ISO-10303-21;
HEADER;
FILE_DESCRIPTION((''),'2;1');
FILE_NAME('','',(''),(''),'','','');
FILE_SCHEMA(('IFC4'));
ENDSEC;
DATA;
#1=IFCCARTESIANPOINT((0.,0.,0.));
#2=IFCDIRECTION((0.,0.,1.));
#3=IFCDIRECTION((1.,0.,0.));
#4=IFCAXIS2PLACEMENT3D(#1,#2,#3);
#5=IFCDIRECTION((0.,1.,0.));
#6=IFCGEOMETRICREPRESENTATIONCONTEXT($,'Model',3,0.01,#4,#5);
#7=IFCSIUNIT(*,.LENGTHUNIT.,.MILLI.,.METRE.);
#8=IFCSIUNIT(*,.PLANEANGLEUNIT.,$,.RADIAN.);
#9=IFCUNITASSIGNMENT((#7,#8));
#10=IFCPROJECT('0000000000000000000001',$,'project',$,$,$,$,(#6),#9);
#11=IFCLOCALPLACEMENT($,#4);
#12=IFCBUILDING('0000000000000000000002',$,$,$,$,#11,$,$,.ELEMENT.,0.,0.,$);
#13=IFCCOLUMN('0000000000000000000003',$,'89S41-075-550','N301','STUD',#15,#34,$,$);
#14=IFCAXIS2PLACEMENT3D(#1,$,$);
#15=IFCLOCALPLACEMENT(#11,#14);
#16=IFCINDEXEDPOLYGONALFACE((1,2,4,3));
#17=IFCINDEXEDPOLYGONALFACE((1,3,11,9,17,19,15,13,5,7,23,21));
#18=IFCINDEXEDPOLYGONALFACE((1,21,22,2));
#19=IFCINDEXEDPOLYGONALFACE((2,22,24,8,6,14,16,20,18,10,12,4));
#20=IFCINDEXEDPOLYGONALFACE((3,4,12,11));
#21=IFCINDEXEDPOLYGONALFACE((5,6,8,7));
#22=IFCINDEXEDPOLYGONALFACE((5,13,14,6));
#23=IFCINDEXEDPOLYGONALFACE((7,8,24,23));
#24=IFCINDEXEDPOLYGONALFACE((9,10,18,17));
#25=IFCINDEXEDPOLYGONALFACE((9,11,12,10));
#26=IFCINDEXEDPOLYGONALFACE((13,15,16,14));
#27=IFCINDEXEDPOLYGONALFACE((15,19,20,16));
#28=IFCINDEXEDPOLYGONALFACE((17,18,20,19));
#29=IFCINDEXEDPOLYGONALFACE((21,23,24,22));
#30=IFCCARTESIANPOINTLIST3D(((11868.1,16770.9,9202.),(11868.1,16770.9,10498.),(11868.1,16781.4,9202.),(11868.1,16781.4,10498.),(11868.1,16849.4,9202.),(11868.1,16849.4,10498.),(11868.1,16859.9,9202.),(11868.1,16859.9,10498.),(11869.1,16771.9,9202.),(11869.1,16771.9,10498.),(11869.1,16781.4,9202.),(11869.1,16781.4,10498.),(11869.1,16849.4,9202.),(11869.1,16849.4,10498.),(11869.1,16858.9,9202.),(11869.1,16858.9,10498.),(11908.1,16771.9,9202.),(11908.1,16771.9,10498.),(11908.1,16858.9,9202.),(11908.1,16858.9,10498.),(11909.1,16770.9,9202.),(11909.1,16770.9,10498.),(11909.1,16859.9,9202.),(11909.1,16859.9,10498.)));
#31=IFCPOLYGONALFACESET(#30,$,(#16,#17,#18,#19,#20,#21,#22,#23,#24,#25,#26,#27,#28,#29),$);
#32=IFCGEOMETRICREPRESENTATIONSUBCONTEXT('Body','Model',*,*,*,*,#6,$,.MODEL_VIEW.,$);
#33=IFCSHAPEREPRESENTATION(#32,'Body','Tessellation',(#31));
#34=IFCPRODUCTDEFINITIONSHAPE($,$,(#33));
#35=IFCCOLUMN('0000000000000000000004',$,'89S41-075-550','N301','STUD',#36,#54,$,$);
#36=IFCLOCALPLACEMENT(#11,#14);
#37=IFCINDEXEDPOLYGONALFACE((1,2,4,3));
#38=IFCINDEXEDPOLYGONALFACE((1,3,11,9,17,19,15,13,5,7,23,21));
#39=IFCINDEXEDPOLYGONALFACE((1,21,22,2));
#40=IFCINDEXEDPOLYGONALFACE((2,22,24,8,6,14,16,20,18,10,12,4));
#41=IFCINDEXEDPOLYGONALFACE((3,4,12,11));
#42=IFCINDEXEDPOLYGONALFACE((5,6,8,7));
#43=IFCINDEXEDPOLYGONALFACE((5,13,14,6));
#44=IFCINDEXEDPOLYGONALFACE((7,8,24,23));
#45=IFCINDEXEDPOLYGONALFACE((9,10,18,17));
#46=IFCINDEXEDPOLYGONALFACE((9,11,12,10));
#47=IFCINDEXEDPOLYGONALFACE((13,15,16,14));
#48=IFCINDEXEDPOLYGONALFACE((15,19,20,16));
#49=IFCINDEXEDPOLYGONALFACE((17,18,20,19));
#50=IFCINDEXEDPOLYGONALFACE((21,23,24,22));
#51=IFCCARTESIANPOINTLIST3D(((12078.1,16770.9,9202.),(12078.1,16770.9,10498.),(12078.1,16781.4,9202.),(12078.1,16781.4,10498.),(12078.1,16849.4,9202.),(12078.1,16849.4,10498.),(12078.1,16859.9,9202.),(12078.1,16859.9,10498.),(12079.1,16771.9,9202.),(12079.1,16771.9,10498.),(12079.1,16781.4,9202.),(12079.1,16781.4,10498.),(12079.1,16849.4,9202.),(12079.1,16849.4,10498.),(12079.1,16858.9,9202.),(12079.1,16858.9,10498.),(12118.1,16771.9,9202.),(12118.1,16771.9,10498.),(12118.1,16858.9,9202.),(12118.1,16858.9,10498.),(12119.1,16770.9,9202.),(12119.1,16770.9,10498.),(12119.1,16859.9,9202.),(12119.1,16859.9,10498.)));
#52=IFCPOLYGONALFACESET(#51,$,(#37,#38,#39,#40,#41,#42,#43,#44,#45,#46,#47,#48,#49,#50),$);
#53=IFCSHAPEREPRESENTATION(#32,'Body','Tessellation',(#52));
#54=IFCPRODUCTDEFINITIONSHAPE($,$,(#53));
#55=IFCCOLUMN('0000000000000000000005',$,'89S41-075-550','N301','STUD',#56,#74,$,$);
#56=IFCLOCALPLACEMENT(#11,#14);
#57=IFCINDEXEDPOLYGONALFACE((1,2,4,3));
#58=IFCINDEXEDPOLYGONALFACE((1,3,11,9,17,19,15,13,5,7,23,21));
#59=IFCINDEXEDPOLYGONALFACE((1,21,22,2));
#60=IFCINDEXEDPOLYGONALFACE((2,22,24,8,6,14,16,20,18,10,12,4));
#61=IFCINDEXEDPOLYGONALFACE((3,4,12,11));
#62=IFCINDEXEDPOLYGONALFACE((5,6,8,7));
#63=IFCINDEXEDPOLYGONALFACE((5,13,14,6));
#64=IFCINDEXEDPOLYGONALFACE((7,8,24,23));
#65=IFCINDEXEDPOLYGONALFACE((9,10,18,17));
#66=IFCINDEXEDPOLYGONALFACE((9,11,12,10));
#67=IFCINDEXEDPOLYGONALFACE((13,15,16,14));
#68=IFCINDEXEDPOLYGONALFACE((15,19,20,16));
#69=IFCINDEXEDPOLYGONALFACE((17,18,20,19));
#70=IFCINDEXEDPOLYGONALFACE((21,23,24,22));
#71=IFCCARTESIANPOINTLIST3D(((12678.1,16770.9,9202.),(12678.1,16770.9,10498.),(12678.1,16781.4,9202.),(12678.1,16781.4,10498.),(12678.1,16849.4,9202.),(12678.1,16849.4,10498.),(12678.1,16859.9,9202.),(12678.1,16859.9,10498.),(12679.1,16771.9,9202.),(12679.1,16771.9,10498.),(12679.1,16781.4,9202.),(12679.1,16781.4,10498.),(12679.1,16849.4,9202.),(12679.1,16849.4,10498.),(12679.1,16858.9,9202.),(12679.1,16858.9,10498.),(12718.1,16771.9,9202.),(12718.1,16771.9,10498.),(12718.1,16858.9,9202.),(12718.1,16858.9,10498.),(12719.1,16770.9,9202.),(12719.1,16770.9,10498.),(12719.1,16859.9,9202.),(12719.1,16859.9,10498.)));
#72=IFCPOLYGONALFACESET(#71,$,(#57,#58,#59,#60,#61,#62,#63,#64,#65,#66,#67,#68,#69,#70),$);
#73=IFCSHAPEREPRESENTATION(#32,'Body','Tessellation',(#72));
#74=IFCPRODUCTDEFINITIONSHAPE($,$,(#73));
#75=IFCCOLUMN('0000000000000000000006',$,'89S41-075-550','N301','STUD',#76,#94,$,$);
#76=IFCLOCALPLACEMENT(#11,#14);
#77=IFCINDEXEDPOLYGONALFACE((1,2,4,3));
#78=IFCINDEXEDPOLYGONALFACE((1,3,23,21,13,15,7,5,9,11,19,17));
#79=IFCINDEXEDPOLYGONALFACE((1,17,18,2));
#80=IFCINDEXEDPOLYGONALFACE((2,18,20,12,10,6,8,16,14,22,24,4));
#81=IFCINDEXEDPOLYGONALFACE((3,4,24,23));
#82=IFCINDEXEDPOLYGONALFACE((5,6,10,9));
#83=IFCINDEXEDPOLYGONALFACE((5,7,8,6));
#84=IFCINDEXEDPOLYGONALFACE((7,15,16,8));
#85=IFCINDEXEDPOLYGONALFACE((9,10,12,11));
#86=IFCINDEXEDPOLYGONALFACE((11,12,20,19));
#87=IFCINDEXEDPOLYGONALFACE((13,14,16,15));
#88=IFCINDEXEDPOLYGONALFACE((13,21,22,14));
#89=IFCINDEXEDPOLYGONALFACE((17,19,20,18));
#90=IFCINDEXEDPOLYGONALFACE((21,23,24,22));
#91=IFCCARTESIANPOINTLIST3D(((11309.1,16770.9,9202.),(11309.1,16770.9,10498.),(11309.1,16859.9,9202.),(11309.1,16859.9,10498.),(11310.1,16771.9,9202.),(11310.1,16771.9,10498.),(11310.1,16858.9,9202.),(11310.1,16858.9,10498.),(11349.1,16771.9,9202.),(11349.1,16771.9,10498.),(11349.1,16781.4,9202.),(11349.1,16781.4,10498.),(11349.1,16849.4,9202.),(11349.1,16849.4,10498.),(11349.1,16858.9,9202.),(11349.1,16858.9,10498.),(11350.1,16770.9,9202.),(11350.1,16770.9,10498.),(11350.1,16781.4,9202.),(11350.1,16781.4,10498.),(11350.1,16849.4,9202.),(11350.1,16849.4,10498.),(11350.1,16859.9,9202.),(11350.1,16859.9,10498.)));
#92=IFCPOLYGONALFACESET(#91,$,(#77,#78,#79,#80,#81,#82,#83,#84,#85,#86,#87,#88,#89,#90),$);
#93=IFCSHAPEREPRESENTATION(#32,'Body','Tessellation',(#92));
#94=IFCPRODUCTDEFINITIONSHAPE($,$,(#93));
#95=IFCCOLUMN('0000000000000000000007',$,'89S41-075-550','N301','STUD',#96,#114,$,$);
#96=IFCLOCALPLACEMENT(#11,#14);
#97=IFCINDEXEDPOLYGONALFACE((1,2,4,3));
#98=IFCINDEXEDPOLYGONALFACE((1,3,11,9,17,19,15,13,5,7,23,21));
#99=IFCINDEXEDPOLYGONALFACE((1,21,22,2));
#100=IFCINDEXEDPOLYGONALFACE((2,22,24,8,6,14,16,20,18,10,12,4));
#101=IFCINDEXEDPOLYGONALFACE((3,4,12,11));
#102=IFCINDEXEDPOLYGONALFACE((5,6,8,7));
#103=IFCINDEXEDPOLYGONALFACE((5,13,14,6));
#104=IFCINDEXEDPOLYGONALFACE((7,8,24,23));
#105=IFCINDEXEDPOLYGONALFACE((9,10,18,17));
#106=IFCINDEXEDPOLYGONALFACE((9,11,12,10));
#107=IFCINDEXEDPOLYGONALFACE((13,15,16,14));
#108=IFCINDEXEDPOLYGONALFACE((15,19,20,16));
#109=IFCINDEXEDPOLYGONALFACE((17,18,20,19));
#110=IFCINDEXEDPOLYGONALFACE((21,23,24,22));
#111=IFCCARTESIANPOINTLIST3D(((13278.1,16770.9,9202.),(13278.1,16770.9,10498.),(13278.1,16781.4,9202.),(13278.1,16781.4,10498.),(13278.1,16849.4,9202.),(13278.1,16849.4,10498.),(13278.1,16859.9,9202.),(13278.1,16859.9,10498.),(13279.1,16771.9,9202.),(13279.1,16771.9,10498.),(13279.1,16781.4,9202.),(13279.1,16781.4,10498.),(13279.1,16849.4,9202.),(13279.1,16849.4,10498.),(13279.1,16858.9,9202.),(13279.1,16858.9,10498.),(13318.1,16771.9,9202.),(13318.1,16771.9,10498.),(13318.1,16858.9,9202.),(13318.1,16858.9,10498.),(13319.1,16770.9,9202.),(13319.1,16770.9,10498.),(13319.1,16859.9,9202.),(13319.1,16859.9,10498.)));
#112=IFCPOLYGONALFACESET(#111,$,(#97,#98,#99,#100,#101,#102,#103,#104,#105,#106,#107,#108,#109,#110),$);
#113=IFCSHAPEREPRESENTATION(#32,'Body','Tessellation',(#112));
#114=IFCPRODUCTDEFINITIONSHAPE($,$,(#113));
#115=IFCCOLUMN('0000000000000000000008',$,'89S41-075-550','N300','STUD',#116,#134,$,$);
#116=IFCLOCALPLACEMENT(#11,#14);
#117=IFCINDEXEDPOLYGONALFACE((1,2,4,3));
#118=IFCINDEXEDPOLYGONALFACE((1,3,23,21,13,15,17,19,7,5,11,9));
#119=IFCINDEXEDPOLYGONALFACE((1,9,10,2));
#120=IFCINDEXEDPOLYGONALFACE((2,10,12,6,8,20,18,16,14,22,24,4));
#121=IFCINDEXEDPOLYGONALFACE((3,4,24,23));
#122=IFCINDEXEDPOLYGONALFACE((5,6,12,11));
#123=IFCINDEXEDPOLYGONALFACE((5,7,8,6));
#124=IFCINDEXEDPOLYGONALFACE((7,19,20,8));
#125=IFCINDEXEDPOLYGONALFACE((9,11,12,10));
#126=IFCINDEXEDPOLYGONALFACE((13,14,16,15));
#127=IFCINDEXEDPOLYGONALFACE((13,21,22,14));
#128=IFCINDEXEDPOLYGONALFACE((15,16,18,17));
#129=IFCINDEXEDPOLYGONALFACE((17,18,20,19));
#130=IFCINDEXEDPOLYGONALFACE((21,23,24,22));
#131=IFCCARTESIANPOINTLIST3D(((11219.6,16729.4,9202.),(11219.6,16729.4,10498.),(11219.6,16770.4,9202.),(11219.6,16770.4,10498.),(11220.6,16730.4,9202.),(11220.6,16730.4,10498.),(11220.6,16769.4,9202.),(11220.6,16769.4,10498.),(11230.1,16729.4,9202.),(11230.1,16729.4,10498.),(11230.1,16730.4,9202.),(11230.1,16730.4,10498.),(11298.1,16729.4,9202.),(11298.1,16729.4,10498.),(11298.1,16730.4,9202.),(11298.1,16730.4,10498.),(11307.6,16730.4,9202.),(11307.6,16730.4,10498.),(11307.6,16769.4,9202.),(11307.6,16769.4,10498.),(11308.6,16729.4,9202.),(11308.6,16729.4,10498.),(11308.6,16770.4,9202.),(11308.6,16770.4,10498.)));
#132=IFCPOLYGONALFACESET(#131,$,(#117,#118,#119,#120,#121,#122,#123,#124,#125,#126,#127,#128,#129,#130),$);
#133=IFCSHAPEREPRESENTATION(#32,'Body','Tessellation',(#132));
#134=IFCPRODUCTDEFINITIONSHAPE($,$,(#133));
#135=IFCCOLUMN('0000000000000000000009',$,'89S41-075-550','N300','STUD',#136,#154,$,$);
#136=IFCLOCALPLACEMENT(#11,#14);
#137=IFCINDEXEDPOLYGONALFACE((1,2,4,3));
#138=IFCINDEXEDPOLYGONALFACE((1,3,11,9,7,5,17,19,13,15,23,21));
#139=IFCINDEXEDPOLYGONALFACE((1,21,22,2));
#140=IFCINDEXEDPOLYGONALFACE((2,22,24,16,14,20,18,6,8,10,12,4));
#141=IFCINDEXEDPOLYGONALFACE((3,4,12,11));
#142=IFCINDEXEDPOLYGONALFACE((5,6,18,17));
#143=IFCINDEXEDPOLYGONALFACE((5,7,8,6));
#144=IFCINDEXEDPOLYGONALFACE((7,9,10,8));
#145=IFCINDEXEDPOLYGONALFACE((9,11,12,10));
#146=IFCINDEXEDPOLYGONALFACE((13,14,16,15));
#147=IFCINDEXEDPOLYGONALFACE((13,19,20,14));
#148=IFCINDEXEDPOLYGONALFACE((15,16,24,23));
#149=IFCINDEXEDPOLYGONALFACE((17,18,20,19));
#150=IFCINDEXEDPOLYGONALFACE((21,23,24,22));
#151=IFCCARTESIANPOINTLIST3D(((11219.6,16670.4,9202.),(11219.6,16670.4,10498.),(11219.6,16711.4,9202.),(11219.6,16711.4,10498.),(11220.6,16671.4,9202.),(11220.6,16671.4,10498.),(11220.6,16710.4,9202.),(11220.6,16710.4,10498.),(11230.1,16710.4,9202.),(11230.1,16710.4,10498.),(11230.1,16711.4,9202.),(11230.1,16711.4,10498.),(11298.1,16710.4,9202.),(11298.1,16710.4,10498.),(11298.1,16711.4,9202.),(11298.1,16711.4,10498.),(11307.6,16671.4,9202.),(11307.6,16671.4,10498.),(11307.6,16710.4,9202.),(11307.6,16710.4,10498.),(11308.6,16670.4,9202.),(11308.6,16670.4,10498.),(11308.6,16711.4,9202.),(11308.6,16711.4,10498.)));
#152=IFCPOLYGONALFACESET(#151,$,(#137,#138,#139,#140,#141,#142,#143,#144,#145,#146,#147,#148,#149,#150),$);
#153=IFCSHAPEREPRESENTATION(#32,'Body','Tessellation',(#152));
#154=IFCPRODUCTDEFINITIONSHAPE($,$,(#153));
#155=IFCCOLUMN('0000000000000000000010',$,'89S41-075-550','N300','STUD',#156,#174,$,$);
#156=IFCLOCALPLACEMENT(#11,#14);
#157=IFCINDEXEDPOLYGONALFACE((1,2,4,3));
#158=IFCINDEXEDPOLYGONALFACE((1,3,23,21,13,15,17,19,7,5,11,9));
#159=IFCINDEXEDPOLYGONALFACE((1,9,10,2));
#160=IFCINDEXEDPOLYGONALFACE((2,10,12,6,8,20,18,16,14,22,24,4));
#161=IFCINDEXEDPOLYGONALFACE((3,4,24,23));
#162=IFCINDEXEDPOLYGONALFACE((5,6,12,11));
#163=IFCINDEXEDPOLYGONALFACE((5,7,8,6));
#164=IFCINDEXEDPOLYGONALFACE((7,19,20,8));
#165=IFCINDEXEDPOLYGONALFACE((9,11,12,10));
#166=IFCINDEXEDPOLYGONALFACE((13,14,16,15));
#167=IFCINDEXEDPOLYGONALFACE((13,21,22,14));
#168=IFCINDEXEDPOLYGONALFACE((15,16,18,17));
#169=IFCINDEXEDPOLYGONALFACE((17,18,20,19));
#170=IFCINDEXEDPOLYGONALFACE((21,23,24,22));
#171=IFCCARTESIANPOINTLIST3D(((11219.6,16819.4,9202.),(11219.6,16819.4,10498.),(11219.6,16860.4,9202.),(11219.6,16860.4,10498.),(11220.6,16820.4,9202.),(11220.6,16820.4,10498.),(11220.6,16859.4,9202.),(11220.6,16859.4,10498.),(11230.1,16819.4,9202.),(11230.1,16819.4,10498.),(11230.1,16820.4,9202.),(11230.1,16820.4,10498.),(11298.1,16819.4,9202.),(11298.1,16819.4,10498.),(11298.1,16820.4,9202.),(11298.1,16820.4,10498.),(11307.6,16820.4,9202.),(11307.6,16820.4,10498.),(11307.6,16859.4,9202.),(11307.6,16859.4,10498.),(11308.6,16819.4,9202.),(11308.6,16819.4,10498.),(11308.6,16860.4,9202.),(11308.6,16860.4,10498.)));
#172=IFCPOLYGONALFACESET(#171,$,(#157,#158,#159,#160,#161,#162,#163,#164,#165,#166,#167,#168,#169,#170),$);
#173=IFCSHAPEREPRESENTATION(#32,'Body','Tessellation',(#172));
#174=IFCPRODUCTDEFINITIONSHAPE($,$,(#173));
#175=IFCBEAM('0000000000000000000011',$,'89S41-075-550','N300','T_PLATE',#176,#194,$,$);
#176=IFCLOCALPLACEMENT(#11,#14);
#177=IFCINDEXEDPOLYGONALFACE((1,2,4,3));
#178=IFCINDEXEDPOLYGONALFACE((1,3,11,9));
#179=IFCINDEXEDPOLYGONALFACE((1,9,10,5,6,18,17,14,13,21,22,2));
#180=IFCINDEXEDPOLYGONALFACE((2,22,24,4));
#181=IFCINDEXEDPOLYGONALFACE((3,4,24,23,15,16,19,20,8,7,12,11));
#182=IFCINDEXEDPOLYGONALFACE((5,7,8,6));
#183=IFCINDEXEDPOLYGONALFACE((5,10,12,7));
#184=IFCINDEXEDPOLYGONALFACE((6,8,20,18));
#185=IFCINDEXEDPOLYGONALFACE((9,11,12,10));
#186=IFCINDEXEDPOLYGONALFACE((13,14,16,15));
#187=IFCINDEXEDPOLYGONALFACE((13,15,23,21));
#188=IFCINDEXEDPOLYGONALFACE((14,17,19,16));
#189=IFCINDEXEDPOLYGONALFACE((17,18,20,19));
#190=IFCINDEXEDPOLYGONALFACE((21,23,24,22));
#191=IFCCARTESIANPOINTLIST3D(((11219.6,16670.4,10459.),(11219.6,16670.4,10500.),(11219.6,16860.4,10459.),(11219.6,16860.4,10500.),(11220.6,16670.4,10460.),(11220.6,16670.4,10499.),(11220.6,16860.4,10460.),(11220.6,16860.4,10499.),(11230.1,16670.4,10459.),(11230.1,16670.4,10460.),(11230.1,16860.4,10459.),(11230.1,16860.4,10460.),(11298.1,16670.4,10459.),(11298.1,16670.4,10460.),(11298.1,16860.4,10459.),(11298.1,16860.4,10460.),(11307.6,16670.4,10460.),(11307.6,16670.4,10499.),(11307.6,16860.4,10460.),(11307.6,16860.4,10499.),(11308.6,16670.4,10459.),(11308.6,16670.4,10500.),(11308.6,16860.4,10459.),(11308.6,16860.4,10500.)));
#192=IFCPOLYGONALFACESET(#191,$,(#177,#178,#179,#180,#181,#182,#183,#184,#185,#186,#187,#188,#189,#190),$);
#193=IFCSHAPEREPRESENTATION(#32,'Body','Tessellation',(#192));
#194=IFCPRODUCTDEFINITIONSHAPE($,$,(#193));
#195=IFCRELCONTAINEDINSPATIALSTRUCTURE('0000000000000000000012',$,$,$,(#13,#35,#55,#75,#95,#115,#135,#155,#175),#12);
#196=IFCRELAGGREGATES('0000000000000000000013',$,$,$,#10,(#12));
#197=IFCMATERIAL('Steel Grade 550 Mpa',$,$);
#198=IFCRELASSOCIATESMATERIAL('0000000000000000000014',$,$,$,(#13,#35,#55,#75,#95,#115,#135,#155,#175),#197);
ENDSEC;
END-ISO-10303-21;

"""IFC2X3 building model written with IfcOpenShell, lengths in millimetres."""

from ifc_helpers import new_model, si_unit, direction, frame, origin, origin_with_axes, origin_2d_with_axis, place, context, subcontext, project, spatial, c_section, extrude, source, transform, mapped, material, element, save


model = new_model("IFC2X3")

# Units and contexts
model_context = context("Model", 3, precision=0.01, world=origin_with_axes(), true_north=direction((0.0, 1.0, 0.0)))
body_context = subcontext(model_context, "Body", "Model", "MODEL_VIEW")
ifc_project = project(units=[si_unit("LENGTHUNIT", "METRE", prefix="MILLI"), si_unit("PLANEANGLEUNIT", "RADIAN")], contexts=[model_context])

# Building
building_placement = place(None, origin_with_axes())
building = spatial("IfcBuilding", under=ifc_project, at=building_placement, CompositionType="ELEMENT", ElevationOfRefHeight=0.0, ElevationOfTerrain=0.0)

# Columns
ifc_material_1 = material(Name="Steel Grade 550 Mpa")
shared_shape_1 = source(origin(), body_context, "Body", "SweptSolid", [
    extrude(c_section(Depth=89.0, Width=41.0, WallThickness=1.0, Girth=10.5, at=origin_2d_with_axis()), origin_with_axes(), (0.0, 0.0, 1.0), 1296.0),
])
column_1_placement = place(None, frame((11888.6, 16815.4, 9202.0), z_axis=(0.0, 0.0, 1.0), x_axis=(-1.0, 0.0, 0.0)))
element("IfcColumn", 1, at=column_1_placement, inside=building, material=ifc_material_1, Name="89S41-075-550", Description="N301", ObjectType="STUD", context=body_context, shape_type="MappedRepresentation", body=[
    mapped(shared_shape_1, transform((0.0, 0.0, 0.0), scale=1.0)),
])
shared_shape_2 = source(origin(), body_context, "Body", "SweptSolid", [
    extrude(c_section(Depth=89.0, Width=41.0, WallThickness=1.0, Girth=10.5, at=origin_2d_with_axis()), origin_with_axes(), (0.0, 0.0, 1.0), 1296.0),
])
column_2_placement = place(None, frame((12098.6, 16815.4, 9202.0), z_axis=(0.0, 0.0, 1.0), x_axis=(-1.0, 0.0, 0.0)))
element("IfcColumn", 2, at=column_2_placement, inside=building, material=ifc_material_1, Name="89S41-075-550", Description="N301", ObjectType="STUD", context=body_context, shape_type="MappedRepresentation", body=[
    mapped(shared_shape_2, transform((0.0, 0.0, 0.0), scale=1.0)),
])
shared_shape_3 = source(origin(), body_context, "Body", "SweptSolid", [
    extrude(c_section(Depth=89.0, Width=41.0, WallThickness=1.0, Girth=10.5, at=origin_2d_with_axis()), origin_with_axes(), (0.0, 0.0, 1.0), 1296.0),
])
column_3_placement = place(None, frame((12698.6, 16815.4, 9202.0), z_axis=(0.0, 0.0, 1.0), x_axis=(-1.0, 0.0, 0.0)))
element("IfcColumn", 3, at=column_3_placement, inside=building, material=ifc_material_1, Name="89S41-075-550", Description="N301", ObjectType="STUD", context=body_context, shape_type="MappedRepresentation", body=[
    mapped(shared_shape_3, transform((0.0, 0.0, 0.0), scale=1.0)),
])
shared_shape_4 = source(origin(), body_context, "Body", "SweptSolid", [
    extrude(c_section(Depth=89.0, Width=41.0, WallThickness=1.0, Girth=10.5, at=origin_2d_with_axis()), origin_with_axes(), (0.0, 0.0, 1.0), 1296.0),
])
column_4_placement = place(None, frame((11329.6, 16815.4, 9202.0), z_axis=(0.0, 0.0, 1.0), x_axis=(1.0, 0.0, 0.0)))
element("IfcColumn", 4, at=column_4_placement, inside=building, material=ifc_material_1, Name="89S41-075-550", Description="N301", ObjectType="STUD", context=body_context, shape_type="MappedRepresentation", body=[
    mapped(shared_shape_4, transform((0.0, 0.0, 0.0), scale=1.0)),
])
shared_shape_5 = source(origin(), body_context, "Body", "SweptSolid", [
    extrude(c_section(Depth=89.0, Width=41.0, WallThickness=1.0, Girth=10.5, at=origin_2d_with_axis()), origin_with_axes(), (0.0, 0.0, 1.0), 1296.0),
])
column_5_placement = place(None, frame((13298.6, 16815.4, 9202.0), z_axis=(0.0, 0.0, 1.0), x_axis=(-1.0, 0.0, 0.0)))
element("IfcColumn", 5, at=column_5_placement, inside=building, material=ifc_material_1, Name="89S41-075-550", Description="N301", ObjectType="STUD", context=body_context, shape_type="MappedRepresentation", body=[
    mapped(shared_shape_5, transform((0.0, 0.0, 0.0), scale=1.0)),
])
shared_shape_6 = source(origin(), body_context, "Body", "SweptSolid", [
    extrude(c_section(Depth=89.0, Width=41.0, WallThickness=1.0, Girth=10.5, at=origin_2d_with_axis()), origin_with_axes(), (0.0, 0.0, 1.0), 1296.0),
])
column_6_placement = place(None, frame((11264.1, 16749.9, 9202.0), z_axis=(0.0, 0.0, 1.0), x_axis=(0.0, -1.0, 0.0)))
element("IfcColumn", 6, at=column_6_placement, inside=building, material=ifc_material_1, Name="89S41-075-550", Description="N300", ObjectType="STUD", context=body_context, shape_type="MappedRepresentation", body=[
    mapped(shared_shape_6, transform((0.0, 0.0, 0.0), scale=1.0)),
])
shared_shape_7 = source(origin(), body_context, "Body", "SweptSolid", [
    extrude(c_section(Depth=89.0, Width=41.0, WallThickness=1.0, Girth=10.5, at=origin_2d_with_axis()), origin_with_axes(), (0.0, 0.0, 1.0), 1296.0),
])
column_7_placement = place(None, frame((11264.1, 16690.9, 9202.0), z_axis=(0.0, 0.0, 1.0), x_axis=(0.0, 1.0, 0.0)))
element("IfcColumn", 7, at=column_7_placement, inside=building, material=ifc_material_1, Name="89S41-075-550", Description="N300", ObjectType="STUD", context=body_context, shape_type="MappedRepresentation", body=[
    mapped(shared_shape_7, transform((0.0, 0.0, 0.0), scale=1.0)),
])
shared_shape_8 = source(origin(), body_context, "Body", "SweptSolid", [
    extrude(c_section(Depth=89.0, Width=41.0, WallThickness=1.0, Girth=10.5, at=origin_2d_with_axis()), origin_with_axes(), (0.0, 0.0, 1.0), 1296.0),
])
column_8_placement = place(None, frame((11264.1, 16839.9, 9202.0), z_axis=(0.0, 0.0, 1.0), x_axis=(0.0, -1.0, 0.0)))
element("IfcColumn", 8, at=column_8_placement, inside=building, material=ifc_material_1, Name="89S41-075-550", Description="N300", ObjectType="STUD", context=body_context, shape_type="MappedRepresentation", body=[
    mapped(shared_shape_8, transform((0.0, 0.0, 0.0), scale=1.0)),
])

# Beam
shared_shape_9 = source(origin(), body_context, "Body", "SweptSolid", [
    extrude(c_section(Depth=89.0, Width=41.0, WallThickness=1.0, Girth=10.5, at=origin_2d_with_axis()), origin_with_axes(), (0.0, 0.0, 1.0), 190.0),
])
beam_1_placement = place(None, frame((11264.1, 16860.4, 10479.5), z_axis=(0.0, -1.0, 0.0), x_axis=(0.0, 0.0, -1.0)))
element("IfcBeam", 9, at=beam_1_placement, inside=building, material=ifc_material_1, Name="89S41-075-550", Description="N300", ObjectType="T_PLATE", context=body_context, shape_type="MappedRepresentation", body=[
    mapped(shared_shape_9, transform((0.0, 0.0, 0.0), scale=1.0)),
])

save(model, "model.ifc")
